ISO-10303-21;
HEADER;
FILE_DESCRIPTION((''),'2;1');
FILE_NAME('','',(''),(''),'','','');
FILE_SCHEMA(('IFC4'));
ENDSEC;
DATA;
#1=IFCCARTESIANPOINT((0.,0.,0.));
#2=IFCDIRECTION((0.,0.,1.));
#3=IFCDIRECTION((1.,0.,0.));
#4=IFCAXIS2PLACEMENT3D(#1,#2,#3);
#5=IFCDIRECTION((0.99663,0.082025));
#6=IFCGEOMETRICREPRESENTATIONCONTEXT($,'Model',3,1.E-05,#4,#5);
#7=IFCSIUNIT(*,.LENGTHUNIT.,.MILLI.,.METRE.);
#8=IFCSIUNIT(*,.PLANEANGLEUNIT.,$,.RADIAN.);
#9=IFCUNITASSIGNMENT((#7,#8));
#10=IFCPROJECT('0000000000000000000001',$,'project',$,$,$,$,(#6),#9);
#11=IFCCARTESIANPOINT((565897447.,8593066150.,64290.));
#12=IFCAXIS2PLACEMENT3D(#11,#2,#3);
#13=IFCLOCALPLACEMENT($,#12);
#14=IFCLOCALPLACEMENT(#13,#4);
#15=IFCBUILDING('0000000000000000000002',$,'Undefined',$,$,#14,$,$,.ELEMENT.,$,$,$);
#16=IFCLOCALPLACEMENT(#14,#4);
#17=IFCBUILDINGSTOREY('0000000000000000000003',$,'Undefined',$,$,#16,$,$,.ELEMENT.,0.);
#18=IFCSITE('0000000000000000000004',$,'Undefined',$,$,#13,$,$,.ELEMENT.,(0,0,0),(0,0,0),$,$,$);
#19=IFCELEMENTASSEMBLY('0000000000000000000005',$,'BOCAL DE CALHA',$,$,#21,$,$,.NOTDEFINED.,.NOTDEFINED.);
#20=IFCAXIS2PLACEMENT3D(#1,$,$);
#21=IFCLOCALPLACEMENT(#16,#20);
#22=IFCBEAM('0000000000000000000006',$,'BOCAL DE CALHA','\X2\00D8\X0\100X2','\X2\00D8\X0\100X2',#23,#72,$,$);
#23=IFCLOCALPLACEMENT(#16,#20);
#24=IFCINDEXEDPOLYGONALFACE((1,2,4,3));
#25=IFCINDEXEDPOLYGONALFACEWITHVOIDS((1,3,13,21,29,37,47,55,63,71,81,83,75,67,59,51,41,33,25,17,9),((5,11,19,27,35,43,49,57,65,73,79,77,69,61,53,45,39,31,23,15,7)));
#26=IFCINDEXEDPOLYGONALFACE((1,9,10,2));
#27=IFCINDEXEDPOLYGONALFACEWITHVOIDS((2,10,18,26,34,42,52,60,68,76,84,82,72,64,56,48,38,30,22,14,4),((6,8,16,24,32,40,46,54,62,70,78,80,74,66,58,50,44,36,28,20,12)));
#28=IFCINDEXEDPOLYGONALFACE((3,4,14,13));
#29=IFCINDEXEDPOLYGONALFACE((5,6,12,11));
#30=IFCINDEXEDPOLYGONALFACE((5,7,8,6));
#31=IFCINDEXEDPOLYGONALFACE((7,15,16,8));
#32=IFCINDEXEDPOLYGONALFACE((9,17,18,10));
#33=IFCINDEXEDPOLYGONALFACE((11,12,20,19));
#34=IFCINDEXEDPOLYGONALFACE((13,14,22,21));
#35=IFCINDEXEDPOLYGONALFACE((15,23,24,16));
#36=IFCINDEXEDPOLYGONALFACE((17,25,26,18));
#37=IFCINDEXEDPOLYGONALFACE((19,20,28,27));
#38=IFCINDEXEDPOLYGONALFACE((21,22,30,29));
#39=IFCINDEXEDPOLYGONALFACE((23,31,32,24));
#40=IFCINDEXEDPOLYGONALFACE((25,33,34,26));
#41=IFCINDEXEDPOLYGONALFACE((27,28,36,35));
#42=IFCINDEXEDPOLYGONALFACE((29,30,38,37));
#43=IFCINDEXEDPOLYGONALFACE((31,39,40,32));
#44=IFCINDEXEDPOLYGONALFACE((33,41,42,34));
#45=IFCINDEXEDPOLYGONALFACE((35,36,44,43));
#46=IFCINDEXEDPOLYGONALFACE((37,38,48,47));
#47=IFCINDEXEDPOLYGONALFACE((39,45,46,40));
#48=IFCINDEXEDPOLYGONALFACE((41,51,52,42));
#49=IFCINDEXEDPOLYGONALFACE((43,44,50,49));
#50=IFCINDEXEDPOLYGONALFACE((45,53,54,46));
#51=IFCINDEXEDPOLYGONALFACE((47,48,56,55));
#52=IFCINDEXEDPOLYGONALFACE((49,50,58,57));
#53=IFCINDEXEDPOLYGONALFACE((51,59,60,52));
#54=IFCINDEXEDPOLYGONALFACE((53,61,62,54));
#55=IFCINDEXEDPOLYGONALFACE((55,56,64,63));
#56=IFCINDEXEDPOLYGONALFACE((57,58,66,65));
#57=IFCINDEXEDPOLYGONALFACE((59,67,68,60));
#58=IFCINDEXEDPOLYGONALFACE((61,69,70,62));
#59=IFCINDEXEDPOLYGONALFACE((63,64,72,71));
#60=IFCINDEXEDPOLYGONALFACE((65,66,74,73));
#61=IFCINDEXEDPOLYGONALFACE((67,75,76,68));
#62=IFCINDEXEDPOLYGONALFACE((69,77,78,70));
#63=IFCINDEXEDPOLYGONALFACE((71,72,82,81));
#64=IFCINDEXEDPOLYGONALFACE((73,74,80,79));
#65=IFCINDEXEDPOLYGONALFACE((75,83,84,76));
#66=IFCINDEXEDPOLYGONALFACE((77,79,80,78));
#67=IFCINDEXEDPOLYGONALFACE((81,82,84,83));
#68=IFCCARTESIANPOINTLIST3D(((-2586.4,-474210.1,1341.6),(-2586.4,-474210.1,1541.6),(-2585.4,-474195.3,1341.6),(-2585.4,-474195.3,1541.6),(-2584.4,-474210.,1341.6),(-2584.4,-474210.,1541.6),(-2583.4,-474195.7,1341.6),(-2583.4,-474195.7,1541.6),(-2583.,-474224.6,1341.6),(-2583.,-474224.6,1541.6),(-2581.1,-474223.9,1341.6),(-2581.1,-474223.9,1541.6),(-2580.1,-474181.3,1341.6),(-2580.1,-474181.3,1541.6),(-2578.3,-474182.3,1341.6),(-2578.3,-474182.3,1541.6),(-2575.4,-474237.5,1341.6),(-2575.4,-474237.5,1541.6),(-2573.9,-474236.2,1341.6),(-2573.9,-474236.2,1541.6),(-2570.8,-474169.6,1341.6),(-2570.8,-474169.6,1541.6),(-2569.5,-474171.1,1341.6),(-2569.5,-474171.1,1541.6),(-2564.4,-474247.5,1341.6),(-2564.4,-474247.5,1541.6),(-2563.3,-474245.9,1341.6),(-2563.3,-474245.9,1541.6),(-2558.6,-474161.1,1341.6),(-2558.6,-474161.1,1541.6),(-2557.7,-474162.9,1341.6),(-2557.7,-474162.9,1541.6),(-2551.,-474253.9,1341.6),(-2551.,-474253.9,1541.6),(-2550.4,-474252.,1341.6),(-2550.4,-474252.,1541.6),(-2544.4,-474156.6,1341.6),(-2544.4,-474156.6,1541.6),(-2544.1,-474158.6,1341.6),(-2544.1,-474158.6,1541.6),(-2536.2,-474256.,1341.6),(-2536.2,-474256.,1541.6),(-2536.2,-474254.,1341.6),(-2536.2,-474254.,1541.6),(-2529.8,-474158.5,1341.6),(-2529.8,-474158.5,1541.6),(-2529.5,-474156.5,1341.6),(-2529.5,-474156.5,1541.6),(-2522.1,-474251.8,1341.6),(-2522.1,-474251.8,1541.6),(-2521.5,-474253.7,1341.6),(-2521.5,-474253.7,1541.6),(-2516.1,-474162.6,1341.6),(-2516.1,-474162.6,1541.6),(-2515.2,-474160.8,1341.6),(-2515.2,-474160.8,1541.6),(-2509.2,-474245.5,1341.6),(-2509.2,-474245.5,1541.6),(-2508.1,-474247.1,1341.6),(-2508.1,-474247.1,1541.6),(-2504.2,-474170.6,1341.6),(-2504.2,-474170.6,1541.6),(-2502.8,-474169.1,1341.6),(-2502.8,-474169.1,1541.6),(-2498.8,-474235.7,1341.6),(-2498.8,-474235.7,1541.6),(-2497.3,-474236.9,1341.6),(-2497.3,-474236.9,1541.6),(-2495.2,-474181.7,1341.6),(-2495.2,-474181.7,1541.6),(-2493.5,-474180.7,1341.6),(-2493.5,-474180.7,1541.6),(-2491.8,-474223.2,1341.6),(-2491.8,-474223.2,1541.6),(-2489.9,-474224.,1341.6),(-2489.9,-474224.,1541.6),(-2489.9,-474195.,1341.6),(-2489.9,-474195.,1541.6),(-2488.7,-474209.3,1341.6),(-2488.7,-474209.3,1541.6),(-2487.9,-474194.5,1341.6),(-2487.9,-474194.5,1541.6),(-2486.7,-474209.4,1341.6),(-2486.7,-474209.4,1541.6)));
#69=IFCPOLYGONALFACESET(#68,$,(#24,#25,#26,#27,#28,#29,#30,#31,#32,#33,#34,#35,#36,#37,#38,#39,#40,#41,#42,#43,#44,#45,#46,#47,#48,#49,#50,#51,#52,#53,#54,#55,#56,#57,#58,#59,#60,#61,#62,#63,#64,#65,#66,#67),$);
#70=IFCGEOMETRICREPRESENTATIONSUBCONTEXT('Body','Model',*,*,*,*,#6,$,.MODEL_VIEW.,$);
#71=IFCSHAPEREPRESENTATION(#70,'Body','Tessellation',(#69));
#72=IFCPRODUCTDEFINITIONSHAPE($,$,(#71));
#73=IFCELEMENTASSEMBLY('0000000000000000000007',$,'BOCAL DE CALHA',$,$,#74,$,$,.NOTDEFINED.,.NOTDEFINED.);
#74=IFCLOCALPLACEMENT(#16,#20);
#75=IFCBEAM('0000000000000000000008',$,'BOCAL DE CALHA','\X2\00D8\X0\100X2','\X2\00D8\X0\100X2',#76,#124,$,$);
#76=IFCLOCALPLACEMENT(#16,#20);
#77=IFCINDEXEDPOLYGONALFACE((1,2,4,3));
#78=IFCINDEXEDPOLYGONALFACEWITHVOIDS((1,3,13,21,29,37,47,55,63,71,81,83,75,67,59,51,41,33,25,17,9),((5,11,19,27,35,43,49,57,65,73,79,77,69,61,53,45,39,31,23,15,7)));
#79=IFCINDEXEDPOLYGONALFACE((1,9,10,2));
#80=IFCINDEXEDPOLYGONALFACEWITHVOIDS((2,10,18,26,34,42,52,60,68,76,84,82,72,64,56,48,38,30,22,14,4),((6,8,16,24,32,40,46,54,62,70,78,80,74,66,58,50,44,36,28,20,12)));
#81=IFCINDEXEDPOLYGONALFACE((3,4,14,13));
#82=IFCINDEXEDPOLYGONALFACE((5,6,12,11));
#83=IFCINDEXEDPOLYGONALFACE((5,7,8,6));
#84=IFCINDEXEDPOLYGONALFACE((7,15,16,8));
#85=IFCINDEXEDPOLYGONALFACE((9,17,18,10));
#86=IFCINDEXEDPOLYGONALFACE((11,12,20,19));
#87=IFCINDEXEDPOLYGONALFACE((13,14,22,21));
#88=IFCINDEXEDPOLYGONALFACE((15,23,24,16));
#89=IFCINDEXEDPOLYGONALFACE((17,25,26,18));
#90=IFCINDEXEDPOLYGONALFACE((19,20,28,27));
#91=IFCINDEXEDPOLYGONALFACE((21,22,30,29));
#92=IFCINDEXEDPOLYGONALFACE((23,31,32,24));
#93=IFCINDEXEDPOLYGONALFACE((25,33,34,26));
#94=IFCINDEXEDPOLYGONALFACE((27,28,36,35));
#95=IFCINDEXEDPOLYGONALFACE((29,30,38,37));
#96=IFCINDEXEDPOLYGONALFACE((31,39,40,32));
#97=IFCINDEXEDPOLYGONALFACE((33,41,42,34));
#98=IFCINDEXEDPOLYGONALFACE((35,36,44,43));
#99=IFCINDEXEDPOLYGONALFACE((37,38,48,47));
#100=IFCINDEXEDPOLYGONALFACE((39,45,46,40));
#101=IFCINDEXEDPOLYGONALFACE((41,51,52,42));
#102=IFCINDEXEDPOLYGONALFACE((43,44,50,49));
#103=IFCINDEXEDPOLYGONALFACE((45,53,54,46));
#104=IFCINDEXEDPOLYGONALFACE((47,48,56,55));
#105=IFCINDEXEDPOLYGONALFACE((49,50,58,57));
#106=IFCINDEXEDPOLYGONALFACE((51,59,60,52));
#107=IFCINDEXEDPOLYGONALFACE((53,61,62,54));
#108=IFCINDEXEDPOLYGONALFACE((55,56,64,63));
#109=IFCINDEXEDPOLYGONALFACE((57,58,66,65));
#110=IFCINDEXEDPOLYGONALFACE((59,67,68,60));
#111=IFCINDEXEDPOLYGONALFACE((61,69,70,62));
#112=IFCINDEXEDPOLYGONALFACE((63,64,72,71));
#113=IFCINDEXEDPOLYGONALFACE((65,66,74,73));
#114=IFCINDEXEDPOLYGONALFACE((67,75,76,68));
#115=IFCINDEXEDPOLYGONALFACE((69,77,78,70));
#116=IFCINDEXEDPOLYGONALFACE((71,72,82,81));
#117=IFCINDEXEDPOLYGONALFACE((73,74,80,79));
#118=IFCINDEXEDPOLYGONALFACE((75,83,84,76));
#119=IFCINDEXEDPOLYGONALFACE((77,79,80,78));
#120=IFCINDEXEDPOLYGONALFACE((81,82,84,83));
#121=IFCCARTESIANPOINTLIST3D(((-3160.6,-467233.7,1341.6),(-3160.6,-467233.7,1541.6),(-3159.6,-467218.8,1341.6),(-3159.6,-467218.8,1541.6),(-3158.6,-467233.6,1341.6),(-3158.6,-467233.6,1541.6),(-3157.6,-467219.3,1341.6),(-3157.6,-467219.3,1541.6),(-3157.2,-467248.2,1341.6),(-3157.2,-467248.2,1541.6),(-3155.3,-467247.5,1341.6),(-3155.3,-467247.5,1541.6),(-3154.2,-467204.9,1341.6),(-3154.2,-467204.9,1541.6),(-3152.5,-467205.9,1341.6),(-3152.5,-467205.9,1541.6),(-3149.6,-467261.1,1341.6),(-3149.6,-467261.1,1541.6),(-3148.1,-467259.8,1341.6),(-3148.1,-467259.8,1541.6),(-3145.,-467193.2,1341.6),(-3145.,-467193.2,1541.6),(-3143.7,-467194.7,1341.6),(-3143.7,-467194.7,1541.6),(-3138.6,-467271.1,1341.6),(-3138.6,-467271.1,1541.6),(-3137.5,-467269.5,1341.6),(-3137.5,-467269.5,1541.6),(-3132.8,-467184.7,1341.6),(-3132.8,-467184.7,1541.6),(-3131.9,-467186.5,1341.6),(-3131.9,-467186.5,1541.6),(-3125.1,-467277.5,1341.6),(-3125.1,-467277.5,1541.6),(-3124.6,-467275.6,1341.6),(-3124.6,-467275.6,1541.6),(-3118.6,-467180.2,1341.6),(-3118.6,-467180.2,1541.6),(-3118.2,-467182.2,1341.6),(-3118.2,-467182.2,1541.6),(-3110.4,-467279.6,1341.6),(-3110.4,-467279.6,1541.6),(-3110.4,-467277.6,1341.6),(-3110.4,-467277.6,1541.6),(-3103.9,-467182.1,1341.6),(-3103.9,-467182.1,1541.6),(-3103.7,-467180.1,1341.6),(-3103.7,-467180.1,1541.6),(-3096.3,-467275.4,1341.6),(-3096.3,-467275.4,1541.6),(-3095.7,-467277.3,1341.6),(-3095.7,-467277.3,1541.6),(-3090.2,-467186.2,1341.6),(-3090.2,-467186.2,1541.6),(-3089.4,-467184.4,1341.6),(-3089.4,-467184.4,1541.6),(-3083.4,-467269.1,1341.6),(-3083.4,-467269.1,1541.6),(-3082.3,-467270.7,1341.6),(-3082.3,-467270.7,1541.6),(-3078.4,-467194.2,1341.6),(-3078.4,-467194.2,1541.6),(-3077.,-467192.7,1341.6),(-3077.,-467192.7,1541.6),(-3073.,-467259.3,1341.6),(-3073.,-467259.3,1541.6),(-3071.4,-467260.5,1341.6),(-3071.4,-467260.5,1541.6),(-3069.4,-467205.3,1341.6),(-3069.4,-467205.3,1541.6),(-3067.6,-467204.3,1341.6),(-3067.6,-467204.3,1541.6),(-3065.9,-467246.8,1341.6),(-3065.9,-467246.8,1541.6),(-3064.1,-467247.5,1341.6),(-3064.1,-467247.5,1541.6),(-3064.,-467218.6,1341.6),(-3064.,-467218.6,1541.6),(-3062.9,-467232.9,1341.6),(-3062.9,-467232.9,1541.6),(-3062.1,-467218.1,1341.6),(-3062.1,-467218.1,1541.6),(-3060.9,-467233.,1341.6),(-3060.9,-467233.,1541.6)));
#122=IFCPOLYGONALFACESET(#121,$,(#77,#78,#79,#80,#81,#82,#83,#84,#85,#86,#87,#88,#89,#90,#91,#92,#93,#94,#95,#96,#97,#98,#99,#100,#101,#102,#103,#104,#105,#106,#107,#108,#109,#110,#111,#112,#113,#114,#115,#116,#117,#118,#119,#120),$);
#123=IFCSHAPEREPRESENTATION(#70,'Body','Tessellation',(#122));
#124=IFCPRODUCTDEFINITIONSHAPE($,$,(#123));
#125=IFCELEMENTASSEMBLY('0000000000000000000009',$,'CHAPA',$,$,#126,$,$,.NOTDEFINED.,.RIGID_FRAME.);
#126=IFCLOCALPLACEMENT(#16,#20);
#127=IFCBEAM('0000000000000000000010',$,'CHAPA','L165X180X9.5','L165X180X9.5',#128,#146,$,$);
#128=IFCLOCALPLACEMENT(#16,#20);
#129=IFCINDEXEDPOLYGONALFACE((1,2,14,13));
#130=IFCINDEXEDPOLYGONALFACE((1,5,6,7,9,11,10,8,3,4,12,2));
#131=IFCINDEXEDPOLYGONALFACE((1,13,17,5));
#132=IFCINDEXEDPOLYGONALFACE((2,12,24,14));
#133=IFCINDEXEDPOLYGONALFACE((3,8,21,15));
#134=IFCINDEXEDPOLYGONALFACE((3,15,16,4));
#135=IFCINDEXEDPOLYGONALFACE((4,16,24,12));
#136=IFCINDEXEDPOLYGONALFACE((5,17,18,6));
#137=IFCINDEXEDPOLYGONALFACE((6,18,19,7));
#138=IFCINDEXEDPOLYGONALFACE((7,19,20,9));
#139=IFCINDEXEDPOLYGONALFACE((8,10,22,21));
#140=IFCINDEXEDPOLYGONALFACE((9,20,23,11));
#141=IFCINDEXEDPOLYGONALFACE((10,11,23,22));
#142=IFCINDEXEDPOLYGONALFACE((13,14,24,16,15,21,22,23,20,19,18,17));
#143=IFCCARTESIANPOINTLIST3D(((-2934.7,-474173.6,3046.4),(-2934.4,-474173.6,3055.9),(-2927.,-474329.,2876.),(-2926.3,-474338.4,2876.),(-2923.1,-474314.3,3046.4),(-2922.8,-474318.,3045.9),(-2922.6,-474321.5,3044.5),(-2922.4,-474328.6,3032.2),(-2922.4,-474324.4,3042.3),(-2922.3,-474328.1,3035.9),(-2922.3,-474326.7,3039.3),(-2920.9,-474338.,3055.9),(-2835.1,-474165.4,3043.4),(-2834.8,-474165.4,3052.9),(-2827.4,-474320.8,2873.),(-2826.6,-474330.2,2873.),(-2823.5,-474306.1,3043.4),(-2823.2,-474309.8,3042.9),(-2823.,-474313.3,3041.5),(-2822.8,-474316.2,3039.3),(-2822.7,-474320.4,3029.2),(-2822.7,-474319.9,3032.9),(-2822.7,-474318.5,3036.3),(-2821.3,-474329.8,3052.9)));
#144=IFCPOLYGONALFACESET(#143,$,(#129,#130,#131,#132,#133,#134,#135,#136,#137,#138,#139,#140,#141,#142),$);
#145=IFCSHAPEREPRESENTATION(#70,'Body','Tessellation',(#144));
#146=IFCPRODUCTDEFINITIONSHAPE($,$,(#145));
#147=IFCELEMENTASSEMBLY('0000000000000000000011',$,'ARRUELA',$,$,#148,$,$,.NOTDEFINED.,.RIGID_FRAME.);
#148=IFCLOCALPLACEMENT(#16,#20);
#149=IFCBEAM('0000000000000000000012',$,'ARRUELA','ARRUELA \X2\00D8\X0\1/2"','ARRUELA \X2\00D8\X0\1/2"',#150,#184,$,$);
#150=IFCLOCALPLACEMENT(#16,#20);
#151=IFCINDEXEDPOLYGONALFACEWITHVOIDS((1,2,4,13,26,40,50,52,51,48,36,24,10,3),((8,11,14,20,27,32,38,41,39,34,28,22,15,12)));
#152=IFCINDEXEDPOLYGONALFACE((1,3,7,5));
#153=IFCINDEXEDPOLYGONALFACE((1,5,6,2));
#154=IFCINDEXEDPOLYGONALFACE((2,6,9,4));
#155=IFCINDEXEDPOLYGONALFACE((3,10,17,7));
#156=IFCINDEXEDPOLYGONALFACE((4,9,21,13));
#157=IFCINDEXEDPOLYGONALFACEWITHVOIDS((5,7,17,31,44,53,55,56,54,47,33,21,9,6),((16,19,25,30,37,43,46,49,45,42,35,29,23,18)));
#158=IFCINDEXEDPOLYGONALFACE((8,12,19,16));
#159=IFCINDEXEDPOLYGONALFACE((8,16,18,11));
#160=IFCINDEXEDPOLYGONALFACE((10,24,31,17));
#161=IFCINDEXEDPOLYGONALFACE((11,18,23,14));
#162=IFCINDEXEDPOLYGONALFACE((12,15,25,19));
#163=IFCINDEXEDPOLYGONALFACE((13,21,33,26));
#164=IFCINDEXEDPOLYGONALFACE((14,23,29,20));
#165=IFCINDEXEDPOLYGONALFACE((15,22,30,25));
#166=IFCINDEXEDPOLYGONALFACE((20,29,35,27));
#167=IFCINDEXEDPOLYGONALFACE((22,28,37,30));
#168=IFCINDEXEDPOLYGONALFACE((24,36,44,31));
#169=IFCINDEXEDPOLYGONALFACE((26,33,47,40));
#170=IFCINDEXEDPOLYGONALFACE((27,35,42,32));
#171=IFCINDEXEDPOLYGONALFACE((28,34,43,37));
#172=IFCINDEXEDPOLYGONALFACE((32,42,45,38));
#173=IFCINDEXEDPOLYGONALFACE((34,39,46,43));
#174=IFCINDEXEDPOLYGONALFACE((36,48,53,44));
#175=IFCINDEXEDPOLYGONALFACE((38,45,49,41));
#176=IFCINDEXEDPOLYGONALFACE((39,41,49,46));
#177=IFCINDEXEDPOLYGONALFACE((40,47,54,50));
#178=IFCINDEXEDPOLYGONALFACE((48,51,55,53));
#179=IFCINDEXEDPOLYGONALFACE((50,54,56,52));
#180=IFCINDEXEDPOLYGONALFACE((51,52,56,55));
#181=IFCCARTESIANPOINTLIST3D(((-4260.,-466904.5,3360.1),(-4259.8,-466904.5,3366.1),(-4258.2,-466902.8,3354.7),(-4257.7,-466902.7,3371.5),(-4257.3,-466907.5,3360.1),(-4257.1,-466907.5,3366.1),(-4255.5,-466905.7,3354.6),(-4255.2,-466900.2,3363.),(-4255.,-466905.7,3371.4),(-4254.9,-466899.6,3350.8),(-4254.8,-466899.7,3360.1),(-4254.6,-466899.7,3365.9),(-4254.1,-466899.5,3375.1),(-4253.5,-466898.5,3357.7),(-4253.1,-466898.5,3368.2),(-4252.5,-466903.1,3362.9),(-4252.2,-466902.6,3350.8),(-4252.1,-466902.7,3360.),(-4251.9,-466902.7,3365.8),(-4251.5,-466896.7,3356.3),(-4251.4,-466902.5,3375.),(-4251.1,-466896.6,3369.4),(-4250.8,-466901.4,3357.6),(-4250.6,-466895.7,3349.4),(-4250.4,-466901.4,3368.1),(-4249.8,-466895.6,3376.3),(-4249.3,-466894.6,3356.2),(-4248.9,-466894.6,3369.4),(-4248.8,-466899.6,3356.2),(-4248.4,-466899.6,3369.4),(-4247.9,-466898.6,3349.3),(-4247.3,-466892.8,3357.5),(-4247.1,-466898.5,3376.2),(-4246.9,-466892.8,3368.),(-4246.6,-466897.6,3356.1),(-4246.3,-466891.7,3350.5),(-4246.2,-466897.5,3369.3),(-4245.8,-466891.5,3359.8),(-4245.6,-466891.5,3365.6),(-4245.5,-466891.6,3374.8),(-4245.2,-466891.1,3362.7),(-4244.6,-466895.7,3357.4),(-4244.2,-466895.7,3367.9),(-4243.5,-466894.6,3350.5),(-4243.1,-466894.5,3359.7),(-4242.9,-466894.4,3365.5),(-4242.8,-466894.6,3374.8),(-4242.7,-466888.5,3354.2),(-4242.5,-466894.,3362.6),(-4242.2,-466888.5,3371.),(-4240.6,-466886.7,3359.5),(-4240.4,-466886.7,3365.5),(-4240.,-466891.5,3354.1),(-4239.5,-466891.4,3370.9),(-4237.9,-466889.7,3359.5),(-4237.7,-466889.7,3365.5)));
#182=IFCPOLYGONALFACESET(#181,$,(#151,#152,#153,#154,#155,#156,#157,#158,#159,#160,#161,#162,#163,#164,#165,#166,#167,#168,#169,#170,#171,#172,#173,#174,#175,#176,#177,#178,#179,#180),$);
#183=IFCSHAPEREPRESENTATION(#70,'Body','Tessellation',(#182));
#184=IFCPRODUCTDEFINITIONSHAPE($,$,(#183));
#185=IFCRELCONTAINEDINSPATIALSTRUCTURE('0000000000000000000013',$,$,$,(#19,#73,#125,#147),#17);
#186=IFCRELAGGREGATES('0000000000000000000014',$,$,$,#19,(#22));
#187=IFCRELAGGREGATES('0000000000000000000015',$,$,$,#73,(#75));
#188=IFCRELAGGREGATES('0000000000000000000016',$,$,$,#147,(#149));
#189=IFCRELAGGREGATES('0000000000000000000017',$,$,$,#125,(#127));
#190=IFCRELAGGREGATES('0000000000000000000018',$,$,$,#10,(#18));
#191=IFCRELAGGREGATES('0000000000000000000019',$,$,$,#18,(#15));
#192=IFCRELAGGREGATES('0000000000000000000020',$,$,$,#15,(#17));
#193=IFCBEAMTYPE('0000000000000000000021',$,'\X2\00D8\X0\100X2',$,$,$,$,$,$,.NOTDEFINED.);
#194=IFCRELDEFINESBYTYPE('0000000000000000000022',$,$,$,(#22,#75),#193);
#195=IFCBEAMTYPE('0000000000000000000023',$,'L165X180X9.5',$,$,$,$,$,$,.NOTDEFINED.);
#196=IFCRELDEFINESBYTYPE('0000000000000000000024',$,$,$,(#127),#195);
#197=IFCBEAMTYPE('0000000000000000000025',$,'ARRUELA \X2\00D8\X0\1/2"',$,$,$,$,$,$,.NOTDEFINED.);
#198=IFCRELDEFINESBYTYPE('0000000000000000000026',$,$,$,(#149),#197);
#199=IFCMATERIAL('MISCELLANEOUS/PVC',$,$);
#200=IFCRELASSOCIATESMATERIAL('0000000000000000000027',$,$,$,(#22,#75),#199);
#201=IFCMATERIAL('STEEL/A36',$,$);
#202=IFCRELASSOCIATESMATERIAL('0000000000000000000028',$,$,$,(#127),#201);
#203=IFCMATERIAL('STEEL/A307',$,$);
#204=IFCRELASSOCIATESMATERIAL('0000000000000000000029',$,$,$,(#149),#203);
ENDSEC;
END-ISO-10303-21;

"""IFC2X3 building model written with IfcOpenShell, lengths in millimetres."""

from ifc_helpers import new_model, si_unit, direction, frame, origin_with_axes, origin_2d_with_axis, place, context, subcontext, project, spatial, polyline, hollow_circle, l_section, outline, extrude, material, type_object, element, aggregate, save


model = new_model("IFC2X3")

# Units and contexts
model_context = context("Model", 3, precision=1e-05, world=origin_with_axes(), true_north=direction((0.99663, 0.082025)))
body_context = subcontext(model_context, "Body", "Model", "MODEL_VIEW")
ifc_project = project(units=[si_unit("LENGTHUNIT", "METRE", prefix="MILLI"), si_unit("PLANEANGLEUNIT", "RADIAN")], contexts=[model_context])

# Site, building, storey
site_placement = place(None, frame((565897447.0, 8593066150.0, 64290.0), z_axis=(0.0, 0.0, 1.0), x_axis=(1.0, 0.0, 0.0)))
site = spatial("IfcSite", under=ifc_project, at=site_placement, Name="Undefined", CompositionType="ELEMENT", RefLatitude=(0, 0, 0), RefLongitude=(0, 0, 0))
building_placement = place(site_placement, origin_with_axes())
building = spatial("IfcBuilding", under=site, at=building_placement, Name="Undefined", CompositionType="ELEMENT")
storey_placement = place(building_placement, origin_with_axes())
storey = spatial("IfcBuildingStorey", under=building, at=storey_placement, Name="Undefined", CompositionType="ELEMENT", Elevation=0.0)

# Element assemblies, beams
assembly_1_placement = place(storey_placement, origin_with_axes())
assembly_1 = element("IfcElementAssembly", 1, at=assembly_1_placement, inside=storey, Name="BOCAL DE CALHA", AssemblyPlace="NOTDEFINED", PredefinedType="NOTDEFINED")
ifc_material_1 = material(Name="MISCELLANEOUS/PVC")
beam_type_1 = type_object("IfcBeamType", Name="Ø100X2", PredefinedType="NOTDEFINED")
beam_1_placement = place(assembly_1_placement, frame((-2536.6, -474206.0, 1541.6), z_axis=(0.082025, -0.99663, 0.0), x_axis=(0.0, 0.0, -1.0)))
beam_1 = element("IfcBeam", 2, at=beam_1_placement, type_object=beam_type_1, material=ifc_material_1, Name="BOCAL DE CALHA", Description="Ø100X2", ObjectType="Ø100X2", context=body_context, shape_type="SweptSolid", body=[
    extrude(hollow_circle(Radius=50.0, WallThickness=2.0, at=origin_2d_with_axis()), frame((200.0, 0.0, 0.0), z_axis=(-1.0, 0.0, 0.0), x_axis=(0.0, -1.0, 0.0)), (0.0, 0.0, 1.0), 200.0),
])
aggregate(assembly_1, [beam_1])
assembly_2_placement = place(storey_placement, origin_with_axes())
assembly_2 = element("IfcElementAssembly", 3, at=assembly_2_placement, inside=storey, Name="BOCAL DE CALHA", AssemblyPlace="NOTDEFINED", PredefinedType="NOTDEFINED")
beam_2_placement = place(assembly_2_placement, frame((-3110.7, -467229.6, 1541.6), z_axis=(0.082025, -0.99663, 0.0), x_axis=(0.0, 0.0, -1.0)))
beam_2 = element("IfcBeam", 4, at=beam_2_placement, type_object=beam_type_1, material=ifc_material_1, Name="BOCAL DE CALHA", Description="Ø100X2", ObjectType="Ø100X2", context=body_context, shape_type="SweptSolid", body=[
    extrude(hollow_circle(Radius=50.0, WallThickness=2.0, at=origin_2d_with_axis()), frame((200.0, 0.0, 0.0), z_axis=(-1.0, 0.0, 0.0), x_axis=(0.0, -1.0, 0.0)), (0.0, 0.0, 1.0), 200.0),
])
aggregate(assembly_2, [beam_2])
assembly_3_placement = place(storey_placement, origin_with_axes())
assembly_3 = element("IfcElementAssembly", 5, at=assembly_3_placement, inside=storey, Name="CHAPA", AssemblyPlace="NOTDEFINED", PredefinedType="RIGID_FRAME")
ifc_material_2 = material(Name="STEEL/A36")
beam_type_2 = type_object("IfcBeamType", Name="L165X180X9.5", PredefinedType="NOTDEFINED")
beam_3_placement = place(assembly_3_placement, frame((-2830.7, -474247.8, 2963.0), z_axis=(-0.082025, 0.99663, 0.0), x_axis=(-0.996182, -0.081989, 0.029987)))
beam_3 = element("IfcBeam", 6, at=beam_3_placement, type_object=beam_type_2, material=ifc_material_2, Name="CHAPA", Description="L165X180X9.5", ObjectType="L165X180X9.5", context=body_context, shape_type="SweptSolid", body=[
    extrude(l_section(Depth=165.0, Width=180.0, Thickness=9.5, FilletRadius=14.2, at=origin_2d_with_axis()), frame((100.0, 0.0, 0.0), z_axis=(-1.0, 0.0, 0.0), x_axis=(0.0, -1.0, 0.0)), (0.0, 0.0, 1.0), 100.0),
])
assembly_4_placement = place(storey_placement, origin_with_axes())
assembly_4 = element("IfcElementAssembly", 7, at=assembly_4_placement, inside=storey, Name="ARRUELA", AssemblyPlace="NOTDEFINED", PredefinedType="RIGID_FRAME")
ifc_material_3 = material(Name="STEEL/A307")
beam_type_3 = type_object("IfcBeamType", Name="ARRUELA Ø1/2\"", PredefinedType="NOTDEFINED")
beam_4_placement = place(assembly_4_placement, frame((-4247.5, -466898.6, 3362.8), z_axis=(-0.736334, -0.676203, 0.02368), x_axis=(-0.675958, 0.736711, 0.018398)))
beam_4 = element("IfcBeam", 8, at=beam_4_placement, type_object=beam_type_3, material=ifc_material_3, Name="ARRUELA", Description="ARRUELA Ø1/2\"", ObjectType="ARRUELA Ø1/2\"", context=body_context, shape_type="SweptSolid", body=[
    extrude(outline(polyline([(-12.2, 5.9), (-8.4, 10.5), (-3.0, 13.2), (3.0, 13.2), (8.4, 10.5), (12.2, 5.9), (13.5, 0.0), (12.2, -5.9), (8.4, -10.5), (3.0, -13.2), (-3.0, -13.2), (-8.4, -10.5), (-12.2, -5.9), (-13.5, 0.0), (-12.2, 5.9)]), holes=[polyline([(5.3, 4.2), (2.9, 6.1), (0.0, 6.8), (-2.9, 6.1), (-5.3, 4.2), (-6.6, 1.5), (-6.6, -1.5), (-5.3, -4.2), (-2.9, -6.1), (0.0, -6.7), (2.9, -6.1), (5.3, -4.2), (6.6, -1.5), (6.6, 1.5), (5.3, 4.2)])]), frame((4.0, 0.0, 0.0), z_axis=(-1.0, 0.0, 0.0), x_axis=(0.0, -1.0, 0.0)), (0.0, 0.0, 1.0), 4.0),
])
aggregate(assembly_4, [beam_4])

aggregate(assembly_3, [beam_3])

save(model, "model.ifc")
